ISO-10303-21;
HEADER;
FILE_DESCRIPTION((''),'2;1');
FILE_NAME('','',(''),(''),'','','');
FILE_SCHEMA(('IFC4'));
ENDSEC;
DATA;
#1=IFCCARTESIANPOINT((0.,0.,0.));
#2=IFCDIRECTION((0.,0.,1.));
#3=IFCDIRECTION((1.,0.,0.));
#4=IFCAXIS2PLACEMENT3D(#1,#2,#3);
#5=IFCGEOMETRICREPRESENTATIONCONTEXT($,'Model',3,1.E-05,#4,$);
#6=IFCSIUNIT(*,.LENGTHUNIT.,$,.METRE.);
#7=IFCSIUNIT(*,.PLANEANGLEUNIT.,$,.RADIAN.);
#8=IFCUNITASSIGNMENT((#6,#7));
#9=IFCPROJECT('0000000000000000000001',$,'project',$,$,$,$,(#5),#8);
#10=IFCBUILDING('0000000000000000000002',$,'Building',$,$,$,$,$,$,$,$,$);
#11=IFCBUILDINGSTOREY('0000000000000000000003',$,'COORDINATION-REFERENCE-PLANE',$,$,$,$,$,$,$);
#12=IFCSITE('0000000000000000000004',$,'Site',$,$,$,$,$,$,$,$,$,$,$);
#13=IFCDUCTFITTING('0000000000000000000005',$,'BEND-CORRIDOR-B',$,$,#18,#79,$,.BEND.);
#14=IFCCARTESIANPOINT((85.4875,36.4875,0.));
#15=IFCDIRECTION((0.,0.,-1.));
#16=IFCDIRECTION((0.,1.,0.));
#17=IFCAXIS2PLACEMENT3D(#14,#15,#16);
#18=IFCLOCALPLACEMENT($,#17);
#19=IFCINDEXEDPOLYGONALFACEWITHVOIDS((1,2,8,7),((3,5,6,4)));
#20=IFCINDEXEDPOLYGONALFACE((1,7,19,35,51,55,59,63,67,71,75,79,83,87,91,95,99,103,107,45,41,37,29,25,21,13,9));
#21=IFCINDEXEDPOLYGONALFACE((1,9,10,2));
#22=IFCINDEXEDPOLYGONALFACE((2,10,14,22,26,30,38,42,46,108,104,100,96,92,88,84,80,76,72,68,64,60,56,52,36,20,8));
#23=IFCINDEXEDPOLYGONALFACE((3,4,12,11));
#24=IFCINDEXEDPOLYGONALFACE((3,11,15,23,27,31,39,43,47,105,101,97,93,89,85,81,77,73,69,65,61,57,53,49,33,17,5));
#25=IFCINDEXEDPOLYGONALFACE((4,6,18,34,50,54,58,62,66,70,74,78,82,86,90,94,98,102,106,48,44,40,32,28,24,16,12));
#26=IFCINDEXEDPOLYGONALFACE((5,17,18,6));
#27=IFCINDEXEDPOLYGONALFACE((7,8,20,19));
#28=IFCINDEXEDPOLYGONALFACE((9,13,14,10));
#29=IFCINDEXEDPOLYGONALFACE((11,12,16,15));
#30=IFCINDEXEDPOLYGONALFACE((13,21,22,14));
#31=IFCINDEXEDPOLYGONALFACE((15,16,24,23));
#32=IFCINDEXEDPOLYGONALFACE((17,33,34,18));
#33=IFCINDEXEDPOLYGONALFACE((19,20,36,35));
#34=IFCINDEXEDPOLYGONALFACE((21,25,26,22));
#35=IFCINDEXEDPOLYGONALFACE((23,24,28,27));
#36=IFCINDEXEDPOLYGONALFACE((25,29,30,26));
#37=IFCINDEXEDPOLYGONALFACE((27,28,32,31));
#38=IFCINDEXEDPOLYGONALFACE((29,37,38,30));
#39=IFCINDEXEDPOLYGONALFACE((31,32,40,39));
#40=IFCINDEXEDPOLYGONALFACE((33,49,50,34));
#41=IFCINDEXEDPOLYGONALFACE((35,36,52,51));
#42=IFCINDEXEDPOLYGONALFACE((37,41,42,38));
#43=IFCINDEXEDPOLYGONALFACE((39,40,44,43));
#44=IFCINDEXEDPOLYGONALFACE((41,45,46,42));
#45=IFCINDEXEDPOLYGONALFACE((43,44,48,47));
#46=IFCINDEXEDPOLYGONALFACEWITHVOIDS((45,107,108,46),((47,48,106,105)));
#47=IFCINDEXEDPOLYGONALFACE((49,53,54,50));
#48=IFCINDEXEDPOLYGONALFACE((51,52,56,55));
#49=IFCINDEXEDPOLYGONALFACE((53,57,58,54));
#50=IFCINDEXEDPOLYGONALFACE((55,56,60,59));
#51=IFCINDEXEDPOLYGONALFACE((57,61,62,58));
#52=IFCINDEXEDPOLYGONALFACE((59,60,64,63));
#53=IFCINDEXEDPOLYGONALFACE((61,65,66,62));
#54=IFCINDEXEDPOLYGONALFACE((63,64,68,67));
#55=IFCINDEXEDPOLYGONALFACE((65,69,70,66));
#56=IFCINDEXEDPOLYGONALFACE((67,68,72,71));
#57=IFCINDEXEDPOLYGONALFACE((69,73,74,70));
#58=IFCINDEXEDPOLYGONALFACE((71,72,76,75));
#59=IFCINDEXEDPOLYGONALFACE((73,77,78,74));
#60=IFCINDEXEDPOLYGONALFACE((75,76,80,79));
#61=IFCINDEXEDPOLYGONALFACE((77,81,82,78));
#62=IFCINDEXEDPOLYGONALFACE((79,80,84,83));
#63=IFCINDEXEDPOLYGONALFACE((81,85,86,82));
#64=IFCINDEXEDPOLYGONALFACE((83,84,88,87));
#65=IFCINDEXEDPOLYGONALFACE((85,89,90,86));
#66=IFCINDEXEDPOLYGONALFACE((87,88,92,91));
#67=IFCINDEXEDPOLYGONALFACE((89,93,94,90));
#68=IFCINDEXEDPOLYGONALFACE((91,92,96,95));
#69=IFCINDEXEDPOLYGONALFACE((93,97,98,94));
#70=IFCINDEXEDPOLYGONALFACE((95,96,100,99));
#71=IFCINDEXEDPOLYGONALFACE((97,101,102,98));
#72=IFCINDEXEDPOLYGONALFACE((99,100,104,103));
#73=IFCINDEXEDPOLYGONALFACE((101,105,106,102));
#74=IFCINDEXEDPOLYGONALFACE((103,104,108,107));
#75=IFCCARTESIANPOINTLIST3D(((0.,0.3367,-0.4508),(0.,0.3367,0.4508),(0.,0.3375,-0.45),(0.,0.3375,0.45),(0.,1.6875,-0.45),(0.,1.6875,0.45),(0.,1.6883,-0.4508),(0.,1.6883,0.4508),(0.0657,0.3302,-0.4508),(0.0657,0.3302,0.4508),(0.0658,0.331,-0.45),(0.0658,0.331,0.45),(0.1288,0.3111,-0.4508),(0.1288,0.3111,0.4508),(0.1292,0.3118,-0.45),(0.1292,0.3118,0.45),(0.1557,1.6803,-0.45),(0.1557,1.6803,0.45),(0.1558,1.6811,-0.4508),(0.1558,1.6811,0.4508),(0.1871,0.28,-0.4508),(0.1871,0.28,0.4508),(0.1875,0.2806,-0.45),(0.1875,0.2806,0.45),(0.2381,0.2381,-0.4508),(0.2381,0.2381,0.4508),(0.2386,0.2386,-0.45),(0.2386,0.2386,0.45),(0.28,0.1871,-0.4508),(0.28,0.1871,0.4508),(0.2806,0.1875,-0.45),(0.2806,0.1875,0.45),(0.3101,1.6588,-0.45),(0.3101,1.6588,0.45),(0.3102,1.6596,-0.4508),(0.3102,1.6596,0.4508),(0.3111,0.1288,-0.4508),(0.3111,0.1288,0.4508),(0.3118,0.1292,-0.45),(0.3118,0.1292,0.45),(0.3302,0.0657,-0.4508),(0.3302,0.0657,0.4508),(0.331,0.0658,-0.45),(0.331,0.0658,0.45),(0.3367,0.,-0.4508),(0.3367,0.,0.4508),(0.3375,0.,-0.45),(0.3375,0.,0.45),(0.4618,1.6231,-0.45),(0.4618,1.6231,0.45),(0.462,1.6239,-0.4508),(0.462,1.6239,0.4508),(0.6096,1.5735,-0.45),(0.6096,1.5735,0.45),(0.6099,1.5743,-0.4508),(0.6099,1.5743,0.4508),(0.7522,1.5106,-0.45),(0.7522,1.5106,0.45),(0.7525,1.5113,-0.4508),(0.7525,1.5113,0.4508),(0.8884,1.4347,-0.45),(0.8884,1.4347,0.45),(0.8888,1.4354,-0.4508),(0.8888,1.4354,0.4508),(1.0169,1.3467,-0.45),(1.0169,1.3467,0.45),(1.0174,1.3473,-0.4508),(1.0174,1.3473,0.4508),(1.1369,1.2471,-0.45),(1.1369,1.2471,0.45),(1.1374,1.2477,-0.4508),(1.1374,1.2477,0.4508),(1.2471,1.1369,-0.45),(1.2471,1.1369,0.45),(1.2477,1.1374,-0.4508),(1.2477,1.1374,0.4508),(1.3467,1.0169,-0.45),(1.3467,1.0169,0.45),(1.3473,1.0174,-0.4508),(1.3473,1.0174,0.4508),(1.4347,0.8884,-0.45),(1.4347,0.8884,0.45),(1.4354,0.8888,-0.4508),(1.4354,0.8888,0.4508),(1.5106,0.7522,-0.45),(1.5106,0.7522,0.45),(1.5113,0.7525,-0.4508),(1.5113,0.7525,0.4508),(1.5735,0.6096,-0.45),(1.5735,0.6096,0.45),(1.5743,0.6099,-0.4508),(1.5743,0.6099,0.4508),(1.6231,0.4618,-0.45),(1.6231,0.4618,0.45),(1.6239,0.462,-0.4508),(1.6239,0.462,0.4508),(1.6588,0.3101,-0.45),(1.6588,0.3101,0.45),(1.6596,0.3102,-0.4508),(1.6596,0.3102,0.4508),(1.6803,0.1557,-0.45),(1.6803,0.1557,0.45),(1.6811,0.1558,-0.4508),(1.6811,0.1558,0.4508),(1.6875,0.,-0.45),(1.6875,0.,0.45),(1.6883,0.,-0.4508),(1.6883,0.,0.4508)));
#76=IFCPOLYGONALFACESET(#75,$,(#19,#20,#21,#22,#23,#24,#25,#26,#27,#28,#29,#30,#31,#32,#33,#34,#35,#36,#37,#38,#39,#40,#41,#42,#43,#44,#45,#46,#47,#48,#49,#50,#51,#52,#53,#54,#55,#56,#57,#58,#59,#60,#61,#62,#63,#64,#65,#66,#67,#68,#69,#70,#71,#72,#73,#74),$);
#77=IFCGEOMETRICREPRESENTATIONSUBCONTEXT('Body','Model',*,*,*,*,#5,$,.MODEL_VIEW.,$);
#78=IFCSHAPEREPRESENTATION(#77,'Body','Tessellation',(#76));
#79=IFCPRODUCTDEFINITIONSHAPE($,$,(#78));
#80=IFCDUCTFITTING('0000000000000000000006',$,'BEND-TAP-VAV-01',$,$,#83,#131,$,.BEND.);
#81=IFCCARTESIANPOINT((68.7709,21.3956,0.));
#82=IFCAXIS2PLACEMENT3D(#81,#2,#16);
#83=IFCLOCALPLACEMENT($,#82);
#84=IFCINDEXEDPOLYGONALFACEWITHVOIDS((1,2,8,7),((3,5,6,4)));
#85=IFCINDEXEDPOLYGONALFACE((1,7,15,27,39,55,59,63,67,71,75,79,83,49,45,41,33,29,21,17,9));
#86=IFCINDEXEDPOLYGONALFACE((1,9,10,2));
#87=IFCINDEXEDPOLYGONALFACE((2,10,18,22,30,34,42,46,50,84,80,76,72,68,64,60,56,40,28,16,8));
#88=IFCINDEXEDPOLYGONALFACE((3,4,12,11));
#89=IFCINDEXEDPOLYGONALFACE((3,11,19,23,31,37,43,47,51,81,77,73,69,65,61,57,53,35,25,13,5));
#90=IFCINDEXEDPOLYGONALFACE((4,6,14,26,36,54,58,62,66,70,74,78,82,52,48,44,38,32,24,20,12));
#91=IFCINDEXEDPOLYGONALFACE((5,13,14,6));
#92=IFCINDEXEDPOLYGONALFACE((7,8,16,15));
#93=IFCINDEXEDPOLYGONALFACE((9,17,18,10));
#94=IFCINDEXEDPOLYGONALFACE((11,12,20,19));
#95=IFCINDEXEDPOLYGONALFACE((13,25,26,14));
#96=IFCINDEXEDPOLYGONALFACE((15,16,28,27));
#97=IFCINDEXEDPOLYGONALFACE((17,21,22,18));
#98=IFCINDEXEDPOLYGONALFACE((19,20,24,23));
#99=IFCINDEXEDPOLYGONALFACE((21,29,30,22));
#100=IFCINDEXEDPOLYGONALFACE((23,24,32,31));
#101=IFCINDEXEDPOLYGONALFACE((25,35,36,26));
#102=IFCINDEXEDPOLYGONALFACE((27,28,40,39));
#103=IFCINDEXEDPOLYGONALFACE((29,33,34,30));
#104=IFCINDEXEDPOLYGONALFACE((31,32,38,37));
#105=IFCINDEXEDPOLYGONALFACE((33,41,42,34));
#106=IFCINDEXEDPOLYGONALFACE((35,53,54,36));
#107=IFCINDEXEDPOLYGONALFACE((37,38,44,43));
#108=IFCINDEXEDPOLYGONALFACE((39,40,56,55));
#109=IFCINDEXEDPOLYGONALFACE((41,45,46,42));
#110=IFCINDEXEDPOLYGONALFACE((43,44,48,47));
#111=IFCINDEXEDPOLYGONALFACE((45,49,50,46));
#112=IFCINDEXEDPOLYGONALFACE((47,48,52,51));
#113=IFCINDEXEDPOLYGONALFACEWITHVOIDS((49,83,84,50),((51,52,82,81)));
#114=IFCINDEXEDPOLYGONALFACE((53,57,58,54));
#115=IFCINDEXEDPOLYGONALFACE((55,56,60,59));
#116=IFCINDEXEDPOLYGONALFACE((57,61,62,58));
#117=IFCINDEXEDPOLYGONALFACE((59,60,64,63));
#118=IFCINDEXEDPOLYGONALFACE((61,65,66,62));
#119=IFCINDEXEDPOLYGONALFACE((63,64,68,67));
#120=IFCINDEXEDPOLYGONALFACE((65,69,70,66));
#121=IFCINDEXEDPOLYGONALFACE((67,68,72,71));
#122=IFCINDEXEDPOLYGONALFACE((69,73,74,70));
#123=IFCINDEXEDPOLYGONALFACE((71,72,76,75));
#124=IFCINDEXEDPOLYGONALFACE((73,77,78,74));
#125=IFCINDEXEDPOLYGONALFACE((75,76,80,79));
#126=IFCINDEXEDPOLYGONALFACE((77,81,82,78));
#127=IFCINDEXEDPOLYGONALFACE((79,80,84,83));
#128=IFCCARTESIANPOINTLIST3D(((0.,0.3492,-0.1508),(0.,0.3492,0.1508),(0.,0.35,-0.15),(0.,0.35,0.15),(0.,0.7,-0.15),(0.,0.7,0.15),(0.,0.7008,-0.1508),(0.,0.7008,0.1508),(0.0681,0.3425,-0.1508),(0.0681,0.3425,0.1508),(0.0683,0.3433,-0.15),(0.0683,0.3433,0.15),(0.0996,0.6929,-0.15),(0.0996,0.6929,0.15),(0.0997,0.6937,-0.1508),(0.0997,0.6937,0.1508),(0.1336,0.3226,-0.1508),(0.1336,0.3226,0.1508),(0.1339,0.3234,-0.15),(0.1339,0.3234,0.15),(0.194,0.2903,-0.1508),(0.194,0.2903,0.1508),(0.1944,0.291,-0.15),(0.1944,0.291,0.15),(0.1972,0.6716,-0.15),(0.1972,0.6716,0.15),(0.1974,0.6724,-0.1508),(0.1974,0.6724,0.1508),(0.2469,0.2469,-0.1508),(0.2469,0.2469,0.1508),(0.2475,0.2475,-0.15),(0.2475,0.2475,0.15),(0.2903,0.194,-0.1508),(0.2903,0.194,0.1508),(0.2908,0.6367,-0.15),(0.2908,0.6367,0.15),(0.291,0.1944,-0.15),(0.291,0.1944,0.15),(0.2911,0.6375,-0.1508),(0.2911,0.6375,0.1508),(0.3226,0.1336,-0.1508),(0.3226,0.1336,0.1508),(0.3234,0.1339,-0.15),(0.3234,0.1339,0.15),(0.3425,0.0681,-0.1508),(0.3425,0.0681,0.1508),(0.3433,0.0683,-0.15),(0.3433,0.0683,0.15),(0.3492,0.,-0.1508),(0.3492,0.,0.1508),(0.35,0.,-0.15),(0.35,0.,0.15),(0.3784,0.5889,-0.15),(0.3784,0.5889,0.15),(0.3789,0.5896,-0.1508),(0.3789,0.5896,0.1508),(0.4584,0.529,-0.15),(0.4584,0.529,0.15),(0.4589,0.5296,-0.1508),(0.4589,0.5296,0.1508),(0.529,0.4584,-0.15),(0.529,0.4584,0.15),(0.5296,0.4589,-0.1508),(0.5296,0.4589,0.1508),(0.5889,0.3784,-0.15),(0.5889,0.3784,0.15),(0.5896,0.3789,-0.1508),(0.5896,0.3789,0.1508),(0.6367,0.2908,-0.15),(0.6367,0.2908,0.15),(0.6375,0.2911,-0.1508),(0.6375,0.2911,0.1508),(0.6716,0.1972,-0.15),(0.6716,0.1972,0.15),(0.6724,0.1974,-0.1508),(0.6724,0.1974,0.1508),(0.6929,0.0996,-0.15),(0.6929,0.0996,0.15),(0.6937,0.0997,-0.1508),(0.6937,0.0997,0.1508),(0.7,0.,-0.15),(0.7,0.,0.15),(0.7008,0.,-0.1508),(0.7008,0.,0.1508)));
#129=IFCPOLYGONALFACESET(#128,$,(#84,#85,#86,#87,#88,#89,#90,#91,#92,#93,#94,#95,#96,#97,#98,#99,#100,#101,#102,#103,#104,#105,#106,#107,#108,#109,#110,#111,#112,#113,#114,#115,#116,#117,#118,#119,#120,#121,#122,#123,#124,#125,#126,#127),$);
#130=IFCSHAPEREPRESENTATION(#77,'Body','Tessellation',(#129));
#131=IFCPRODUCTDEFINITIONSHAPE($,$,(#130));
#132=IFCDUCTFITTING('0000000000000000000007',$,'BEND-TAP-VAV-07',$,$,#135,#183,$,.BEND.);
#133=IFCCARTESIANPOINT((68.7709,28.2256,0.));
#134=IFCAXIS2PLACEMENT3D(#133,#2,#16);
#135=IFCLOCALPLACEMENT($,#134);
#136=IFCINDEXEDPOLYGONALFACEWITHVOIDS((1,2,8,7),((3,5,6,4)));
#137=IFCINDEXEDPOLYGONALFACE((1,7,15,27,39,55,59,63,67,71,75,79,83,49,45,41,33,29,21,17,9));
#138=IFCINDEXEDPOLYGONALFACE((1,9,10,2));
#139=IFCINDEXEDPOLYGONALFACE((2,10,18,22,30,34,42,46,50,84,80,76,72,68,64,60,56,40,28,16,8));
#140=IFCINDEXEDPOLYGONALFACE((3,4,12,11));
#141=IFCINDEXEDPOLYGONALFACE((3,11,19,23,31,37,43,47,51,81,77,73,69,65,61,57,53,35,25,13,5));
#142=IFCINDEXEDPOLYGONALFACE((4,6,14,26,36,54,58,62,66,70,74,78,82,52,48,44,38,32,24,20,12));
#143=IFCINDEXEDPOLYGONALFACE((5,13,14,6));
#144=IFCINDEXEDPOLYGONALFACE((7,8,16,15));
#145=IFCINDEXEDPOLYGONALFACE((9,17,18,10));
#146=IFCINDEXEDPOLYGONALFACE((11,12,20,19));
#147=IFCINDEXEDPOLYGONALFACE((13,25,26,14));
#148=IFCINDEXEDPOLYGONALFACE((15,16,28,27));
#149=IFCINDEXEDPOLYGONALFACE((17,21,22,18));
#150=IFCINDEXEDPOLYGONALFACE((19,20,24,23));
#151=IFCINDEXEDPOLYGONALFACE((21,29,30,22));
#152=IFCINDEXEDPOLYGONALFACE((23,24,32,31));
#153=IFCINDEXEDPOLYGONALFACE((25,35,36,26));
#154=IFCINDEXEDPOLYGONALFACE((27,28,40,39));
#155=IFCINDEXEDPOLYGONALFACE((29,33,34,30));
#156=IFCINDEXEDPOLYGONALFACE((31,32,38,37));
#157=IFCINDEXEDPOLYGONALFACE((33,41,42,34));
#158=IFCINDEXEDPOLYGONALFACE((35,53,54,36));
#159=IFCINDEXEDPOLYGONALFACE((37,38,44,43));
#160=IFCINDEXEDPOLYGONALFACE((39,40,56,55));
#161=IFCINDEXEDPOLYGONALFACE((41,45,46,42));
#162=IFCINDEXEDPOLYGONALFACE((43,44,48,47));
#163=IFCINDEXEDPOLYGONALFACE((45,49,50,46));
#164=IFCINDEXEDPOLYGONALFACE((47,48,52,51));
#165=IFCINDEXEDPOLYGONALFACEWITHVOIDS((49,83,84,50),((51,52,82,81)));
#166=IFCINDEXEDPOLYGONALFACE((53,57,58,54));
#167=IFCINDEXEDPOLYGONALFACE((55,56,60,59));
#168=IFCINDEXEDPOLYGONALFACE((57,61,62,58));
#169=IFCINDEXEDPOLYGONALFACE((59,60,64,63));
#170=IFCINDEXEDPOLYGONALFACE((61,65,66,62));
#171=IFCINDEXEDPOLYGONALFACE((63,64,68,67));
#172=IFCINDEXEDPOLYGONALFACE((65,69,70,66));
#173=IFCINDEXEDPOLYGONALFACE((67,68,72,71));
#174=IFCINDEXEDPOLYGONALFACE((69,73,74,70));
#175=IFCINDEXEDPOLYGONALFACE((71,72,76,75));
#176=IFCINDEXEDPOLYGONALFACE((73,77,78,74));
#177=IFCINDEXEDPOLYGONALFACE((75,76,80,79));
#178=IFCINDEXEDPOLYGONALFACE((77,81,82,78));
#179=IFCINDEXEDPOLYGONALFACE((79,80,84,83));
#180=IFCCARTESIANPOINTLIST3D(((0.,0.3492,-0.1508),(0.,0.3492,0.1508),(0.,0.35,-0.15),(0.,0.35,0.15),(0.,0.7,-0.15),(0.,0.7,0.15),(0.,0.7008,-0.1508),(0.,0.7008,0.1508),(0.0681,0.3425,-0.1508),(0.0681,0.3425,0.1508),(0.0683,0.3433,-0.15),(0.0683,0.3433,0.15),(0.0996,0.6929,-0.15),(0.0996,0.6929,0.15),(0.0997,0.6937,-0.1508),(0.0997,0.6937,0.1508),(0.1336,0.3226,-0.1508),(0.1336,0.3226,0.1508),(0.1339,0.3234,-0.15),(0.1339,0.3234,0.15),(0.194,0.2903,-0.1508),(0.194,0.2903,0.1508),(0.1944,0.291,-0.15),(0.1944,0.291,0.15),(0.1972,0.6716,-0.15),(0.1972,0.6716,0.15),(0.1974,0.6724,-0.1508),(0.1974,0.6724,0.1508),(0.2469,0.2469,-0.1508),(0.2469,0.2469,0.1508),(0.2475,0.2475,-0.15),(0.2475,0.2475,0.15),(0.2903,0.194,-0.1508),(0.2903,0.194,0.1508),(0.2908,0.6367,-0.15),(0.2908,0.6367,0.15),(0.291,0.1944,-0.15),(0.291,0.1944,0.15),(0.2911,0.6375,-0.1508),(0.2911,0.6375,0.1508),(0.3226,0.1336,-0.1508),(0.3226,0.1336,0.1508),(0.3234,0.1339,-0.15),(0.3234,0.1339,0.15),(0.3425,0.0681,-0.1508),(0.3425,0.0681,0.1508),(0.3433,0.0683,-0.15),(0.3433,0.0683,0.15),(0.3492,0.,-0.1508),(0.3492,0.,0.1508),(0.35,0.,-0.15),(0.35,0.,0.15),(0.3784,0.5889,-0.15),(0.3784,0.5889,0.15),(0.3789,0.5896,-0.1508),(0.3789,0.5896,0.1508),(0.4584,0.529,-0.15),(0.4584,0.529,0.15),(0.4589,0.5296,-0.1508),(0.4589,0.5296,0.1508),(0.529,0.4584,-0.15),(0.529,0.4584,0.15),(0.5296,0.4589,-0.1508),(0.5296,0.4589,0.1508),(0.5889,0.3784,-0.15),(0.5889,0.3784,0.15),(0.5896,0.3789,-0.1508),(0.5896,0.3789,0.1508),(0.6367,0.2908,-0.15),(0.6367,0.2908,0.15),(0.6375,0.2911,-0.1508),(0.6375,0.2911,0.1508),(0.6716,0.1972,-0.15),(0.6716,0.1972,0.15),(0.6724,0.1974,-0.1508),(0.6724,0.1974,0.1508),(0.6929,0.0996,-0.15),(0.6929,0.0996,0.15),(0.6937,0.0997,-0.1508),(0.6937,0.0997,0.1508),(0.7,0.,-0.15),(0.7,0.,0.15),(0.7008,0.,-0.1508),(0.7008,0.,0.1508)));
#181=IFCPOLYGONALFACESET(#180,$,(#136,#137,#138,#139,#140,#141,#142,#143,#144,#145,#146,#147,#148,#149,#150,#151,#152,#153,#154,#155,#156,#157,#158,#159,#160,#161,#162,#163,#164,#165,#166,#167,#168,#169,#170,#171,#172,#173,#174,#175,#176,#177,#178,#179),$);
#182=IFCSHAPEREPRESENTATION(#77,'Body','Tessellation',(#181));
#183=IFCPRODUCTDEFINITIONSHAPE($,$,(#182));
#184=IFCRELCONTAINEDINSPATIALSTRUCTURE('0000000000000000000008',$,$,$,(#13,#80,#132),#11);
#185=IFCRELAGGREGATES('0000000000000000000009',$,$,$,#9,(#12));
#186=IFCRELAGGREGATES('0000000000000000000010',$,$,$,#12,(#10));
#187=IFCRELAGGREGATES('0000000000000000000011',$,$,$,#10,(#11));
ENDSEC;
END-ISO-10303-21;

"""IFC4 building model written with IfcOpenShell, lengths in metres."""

from ifc_helpers import new_model, entity, si_unit, frame, origin_with_axes, place, context, subcontext, project, spatial, element, save


model = new_model("IFC4")

# Units and contexts
model_context = context("Model", 3, precision=1e-05, world=origin_with_axes())
body_context = subcontext(model_context, "Body", "Model", "MODEL_VIEW")
ifc_project = project(units=[si_unit("LENGTHUNIT", "METRE"), si_unit("PLANEANGLEUNIT", "RADIAN")], contexts=[model_context])

# Site, building, storey
site = spatial("IfcSite", under=ifc_project, Name="Site")
building = spatial("IfcBuilding", under=site, Name="Building")
storey = spatial("IfcBuildingStorey", under=building, Name="COORDINATION-REFERENCE-PLANE")

# Duct fittings
duct_fitting_1_placement = place(None, frame((85.4875, 36.4875, 0.0), z_axis=(0.0, 0.0, -1.0), x_axis=(0.0, 1.0, 0.0)))
cartesian_point_1 = entity("IfcCartesianPoint", [0.0, 0.0, 0.0])
element("IfcDuctFitting", 1, at=duct_fitting_1_placement, inside=storey, Name="BEND-CORRIDOR-B", PredefinedType="BEND", context=body_context, shape_type="SweptSolid", body=[
    entity("IfcRevolvedAreaSolid", entity("IfcRectangleHollowProfileDef", "AREA", None, entity("IfcAxis2Placement2D", entity("IfcCartesianPoint", [1.0125, 0.0])), 1.3516, 0.9016, 0.0008), entity("IfcAxis2Placement3D", cartesian_point_1, entity("IfcDirection", [0.0, -1.0, 0.0]), entity("IfcDirection", [1.0, 0.0, 0.0])), entity("IfcAxis1Placement", cartesian_point_1, entity("IfcDirection", [0.0, 1.0, 0.0])), 1.570796),
])
duct_fitting_2_placement = place(None, frame((68.7709, 21.3956, 0.0), z_axis=(0.0, 0.0, 1.0), x_axis=(0.0, 1.0, 0.0)))
cartesian_point_2 = entity("IfcCartesianPoint", [0.0, 0.0, 0.0])
element("IfcDuctFitting", 2, at=duct_fitting_2_placement, inside=storey, Name="BEND-TAP-VAV-01", PredefinedType="BEND", context=body_context, shape_type="SweptSolid", body=[
    entity("IfcRevolvedAreaSolid", entity("IfcRectangleHollowProfileDef", "AREA", None, entity("IfcAxis2Placement2D", entity("IfcCartesianPoint", [0.525, 0.0])), 0.3516, 0.3016, 0.0008), entity("IfcAxis2Placement3D", cartesian_point_2, entity("IfcDirection", [0.0, -1.0, 0.0]), entity("IfcDirection", [1.0, 0.0, 0.0])), entity("IfcAxis1Placement", cartesian_point_2, entity("IfcDirection", [0.0, 1.0, 0.0])), 1.570796),
])
duct_fitting_3_placement = place(None, frame((68.7709, 28.2256, 0.0), z_axis=(0.0, 0.0, 1.0), x_axis=(0.0, 1.0, 0.0)))
cartesian_point_3 = entity("IfcCartesianPoint", [0.0, 0.0, 0.0])
element("IfcDuctFitting", 3, at=duct_fitting_3_placement, inside=storey, Name="BEND-TAP-VAV-07", PredefinedType="BEND", context=body_context, shape_type="SweptSolid", body=[
    entity("IfcRevolvedAreaSolid", entity("IfcRectangleHollowProfileDef", "AREA", None, entity("IfcAxis2Placement2D", entity("IfcCartesianPoint", [0.525, 0.0])), 0.3516, 0.3016, 0.0008), entity("IfcAxis2Placement3D", cartesian_point_3, entity("IfcDirection", [0.0, -1.0, 0.0]), entity("IfcDirection", [1.0, 0.0, 0.0])), entity("IfcAxis1Placement", cartesian_point_3, entity("IfcDirection", [0.0, 1.0, 0.0])), 1.570796),
])

save(model, "model.ifc")
